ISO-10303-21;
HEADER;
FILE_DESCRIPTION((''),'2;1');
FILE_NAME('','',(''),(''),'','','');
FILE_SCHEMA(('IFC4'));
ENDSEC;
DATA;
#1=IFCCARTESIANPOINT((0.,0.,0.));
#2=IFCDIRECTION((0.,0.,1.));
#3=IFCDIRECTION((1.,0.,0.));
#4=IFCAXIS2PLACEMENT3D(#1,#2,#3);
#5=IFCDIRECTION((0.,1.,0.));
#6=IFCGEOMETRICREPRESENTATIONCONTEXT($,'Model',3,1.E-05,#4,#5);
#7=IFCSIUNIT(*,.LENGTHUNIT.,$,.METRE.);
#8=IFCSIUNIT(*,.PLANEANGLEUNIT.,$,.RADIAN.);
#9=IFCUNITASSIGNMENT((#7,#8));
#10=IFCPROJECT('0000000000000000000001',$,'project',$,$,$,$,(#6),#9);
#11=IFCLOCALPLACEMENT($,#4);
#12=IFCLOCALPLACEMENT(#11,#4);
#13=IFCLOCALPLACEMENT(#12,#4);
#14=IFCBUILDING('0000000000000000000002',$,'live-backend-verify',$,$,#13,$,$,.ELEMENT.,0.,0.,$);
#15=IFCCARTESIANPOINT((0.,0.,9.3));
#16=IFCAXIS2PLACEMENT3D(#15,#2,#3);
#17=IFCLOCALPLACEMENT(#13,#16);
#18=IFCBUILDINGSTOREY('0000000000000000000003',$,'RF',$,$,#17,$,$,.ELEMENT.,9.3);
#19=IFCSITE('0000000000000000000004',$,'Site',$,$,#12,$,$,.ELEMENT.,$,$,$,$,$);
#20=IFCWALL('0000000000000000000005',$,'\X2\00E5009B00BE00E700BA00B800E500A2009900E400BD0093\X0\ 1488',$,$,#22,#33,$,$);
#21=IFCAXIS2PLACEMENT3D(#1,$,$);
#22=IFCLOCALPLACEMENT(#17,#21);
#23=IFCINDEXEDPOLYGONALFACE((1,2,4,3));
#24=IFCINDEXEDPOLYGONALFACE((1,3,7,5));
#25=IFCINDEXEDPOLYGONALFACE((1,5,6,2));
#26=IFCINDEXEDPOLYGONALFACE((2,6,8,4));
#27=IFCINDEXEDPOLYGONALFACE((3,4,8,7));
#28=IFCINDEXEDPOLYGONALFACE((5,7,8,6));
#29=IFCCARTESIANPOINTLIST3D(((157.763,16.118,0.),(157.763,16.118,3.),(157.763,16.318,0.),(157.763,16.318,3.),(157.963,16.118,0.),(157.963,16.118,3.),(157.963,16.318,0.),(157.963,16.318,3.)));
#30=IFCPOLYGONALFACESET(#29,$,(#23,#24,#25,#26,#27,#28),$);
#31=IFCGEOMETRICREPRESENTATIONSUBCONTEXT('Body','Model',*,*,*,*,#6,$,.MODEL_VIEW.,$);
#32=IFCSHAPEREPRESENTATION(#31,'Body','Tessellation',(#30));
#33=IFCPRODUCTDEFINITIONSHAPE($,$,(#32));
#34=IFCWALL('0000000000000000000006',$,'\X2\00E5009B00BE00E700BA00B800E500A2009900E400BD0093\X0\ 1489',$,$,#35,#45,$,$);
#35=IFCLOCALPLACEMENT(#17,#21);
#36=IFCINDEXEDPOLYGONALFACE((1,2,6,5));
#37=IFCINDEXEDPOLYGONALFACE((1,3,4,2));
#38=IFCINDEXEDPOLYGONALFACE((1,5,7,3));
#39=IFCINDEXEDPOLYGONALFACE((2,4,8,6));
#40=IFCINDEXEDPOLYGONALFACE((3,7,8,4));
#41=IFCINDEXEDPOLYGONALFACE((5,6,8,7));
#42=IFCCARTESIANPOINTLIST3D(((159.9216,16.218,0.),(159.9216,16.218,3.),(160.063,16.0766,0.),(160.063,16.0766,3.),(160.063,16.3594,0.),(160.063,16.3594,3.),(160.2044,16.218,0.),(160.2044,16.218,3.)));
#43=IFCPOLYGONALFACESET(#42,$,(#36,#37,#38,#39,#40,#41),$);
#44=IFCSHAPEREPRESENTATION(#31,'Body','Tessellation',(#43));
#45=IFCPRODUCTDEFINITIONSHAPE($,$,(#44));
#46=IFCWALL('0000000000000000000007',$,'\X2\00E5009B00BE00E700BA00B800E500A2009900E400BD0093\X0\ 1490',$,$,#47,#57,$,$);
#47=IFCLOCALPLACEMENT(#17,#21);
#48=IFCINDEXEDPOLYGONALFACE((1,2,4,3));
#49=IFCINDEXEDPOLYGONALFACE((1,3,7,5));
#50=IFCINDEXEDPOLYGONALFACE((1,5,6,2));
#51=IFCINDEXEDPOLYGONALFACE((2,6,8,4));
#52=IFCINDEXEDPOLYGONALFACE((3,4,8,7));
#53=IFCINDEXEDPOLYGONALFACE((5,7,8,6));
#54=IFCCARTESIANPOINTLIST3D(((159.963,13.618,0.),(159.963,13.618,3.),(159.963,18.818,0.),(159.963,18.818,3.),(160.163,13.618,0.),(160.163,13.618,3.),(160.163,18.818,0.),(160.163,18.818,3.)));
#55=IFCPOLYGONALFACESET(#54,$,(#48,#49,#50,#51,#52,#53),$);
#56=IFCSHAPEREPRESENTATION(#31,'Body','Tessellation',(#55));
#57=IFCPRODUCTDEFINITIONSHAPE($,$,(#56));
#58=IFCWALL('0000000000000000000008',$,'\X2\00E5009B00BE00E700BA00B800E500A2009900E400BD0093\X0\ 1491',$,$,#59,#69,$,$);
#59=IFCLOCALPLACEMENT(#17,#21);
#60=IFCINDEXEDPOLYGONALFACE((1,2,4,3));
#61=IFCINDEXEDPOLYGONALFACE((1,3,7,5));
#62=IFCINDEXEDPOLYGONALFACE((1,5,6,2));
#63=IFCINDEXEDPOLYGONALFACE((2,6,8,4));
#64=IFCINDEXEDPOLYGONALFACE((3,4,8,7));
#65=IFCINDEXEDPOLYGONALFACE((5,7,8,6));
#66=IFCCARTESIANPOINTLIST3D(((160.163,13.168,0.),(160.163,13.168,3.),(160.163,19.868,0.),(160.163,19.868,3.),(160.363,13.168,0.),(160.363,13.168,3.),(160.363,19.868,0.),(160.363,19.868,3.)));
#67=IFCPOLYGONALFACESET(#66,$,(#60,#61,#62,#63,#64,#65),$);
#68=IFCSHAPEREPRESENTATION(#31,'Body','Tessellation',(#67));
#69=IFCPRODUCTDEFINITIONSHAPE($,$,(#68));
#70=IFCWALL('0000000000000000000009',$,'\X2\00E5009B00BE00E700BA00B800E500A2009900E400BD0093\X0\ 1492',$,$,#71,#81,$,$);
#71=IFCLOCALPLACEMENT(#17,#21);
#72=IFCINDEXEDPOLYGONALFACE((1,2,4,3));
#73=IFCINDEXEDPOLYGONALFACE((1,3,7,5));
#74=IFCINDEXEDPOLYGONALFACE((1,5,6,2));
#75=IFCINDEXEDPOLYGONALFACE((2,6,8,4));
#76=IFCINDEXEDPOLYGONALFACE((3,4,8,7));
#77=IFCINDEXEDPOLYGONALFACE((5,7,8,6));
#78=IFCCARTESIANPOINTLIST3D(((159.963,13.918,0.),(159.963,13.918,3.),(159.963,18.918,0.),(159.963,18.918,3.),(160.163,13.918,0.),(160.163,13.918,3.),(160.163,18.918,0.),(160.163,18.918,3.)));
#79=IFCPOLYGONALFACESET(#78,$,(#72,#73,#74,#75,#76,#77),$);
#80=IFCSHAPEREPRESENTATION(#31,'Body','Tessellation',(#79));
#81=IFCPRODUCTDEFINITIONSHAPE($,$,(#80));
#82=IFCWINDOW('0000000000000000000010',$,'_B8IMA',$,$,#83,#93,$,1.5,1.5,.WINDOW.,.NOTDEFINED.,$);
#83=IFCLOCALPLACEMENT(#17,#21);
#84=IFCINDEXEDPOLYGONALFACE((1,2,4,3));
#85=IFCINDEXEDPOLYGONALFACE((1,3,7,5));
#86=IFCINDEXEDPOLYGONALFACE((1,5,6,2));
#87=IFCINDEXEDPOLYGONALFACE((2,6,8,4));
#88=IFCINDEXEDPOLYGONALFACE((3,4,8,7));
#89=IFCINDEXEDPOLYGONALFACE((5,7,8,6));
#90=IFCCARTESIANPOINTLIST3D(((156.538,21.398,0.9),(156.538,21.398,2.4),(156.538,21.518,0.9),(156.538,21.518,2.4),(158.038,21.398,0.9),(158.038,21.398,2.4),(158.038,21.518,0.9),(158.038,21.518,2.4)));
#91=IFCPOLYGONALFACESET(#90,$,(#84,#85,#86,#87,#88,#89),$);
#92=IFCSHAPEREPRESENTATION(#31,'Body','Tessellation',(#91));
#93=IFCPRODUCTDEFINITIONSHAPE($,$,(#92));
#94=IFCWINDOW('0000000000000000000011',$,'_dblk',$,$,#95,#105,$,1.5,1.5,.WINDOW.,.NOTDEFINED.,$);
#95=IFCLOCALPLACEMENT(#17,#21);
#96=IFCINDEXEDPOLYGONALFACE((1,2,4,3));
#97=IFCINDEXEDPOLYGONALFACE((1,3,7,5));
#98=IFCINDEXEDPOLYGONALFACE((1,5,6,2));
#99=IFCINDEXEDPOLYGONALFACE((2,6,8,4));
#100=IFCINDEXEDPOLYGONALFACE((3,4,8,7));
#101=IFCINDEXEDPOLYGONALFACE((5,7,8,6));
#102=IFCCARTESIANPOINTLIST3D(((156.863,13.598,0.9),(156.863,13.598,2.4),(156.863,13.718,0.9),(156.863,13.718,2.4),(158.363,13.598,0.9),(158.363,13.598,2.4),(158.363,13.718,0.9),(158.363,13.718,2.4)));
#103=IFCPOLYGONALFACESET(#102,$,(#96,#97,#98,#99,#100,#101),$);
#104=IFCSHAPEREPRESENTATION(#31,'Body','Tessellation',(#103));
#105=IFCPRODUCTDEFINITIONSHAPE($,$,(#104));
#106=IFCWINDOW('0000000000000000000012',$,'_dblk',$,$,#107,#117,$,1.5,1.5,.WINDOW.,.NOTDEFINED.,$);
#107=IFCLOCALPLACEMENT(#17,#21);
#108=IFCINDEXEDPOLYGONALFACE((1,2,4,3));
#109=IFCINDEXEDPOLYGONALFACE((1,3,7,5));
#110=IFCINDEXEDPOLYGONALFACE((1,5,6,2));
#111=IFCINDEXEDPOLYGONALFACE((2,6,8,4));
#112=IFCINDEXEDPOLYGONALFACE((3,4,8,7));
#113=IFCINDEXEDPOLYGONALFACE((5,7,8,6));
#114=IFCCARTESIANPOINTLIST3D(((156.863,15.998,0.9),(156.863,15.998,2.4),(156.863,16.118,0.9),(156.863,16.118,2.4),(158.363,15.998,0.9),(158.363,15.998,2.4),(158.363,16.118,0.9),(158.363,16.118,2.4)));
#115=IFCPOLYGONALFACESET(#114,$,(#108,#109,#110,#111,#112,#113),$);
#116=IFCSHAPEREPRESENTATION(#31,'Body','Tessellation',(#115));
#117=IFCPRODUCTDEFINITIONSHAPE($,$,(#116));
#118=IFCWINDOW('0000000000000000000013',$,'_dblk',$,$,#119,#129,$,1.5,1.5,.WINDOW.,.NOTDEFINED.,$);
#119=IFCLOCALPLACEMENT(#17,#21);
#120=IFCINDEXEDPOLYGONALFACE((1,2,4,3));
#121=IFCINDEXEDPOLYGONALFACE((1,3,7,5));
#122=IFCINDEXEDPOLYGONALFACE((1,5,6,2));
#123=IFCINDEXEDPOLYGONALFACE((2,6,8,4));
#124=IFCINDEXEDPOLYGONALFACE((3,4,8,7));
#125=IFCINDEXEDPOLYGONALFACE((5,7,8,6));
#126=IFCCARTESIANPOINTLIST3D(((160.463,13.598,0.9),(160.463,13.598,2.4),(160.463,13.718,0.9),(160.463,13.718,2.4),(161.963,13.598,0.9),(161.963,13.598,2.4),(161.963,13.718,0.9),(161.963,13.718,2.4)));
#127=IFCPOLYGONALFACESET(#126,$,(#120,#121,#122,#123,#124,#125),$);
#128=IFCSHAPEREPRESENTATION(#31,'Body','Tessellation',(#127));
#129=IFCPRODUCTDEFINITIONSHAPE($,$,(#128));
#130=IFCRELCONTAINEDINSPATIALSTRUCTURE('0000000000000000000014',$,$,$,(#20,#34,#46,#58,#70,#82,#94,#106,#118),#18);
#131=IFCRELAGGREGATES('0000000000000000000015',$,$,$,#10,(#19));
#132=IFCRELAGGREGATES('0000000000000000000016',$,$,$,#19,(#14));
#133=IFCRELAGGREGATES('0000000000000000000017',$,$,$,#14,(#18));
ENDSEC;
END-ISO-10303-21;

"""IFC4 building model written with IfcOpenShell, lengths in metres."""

from ifc_helpers import new_model, si_unit, direction, frame, frame_2d, origin_with_axes, place, context, subcontext, project, spatial, rectangle, extrude, element, save


model = new_model("IFC4")

# Units and contexts
model_context = context("Model", 3, precision=1e-05, world=origin_with_axes(), true_north=direction((0.0, 1.0, 0.0)))
body_context = subcontext(model_context, "Body", "Model", "MODEL_VIEW")
ifc_project = project(units=[si_unit("LENGTHUNIT", "METRE"), si_unit("PLANEANGLEUNIT", "RADIAN")], contexts=[model_context])

# Site, building, storey
placement = place(None, origin_with_axes())
site_placement = place(placement, origin_with_axes())
site = spatial("IfcSite", under=ifc_project, at=site_placement, Name="Site", CompositionType="ELEMENT")
building_placement = place(site_placement, origin_with_axes())
building = spatial("IfcBuilding", under=site, at=building_placement, Name="live-backend-verify", CompositionType="ELEMENT", ElevationOfRefHeight=0.0, ElevationOfTerrain=0.0)
storey_placement = place(building_placement, frame((0.0, 0.0, 9.3), z_axis=(0.0, 0.0, 1.0), x_axis=(1.0, 0.0, 0.0)))
storey = spatial("IfcBuildingStorey", under=building, at=storey_placement, Name="RF", CompositionType="ELEMENT", Elevation=9.3)

# Walls
for number, where, z_axis, x_axis, name in (
    (1, (157.863, 16.218, 0.0), (0.0, 0.0, 1.0), (0.0, -1.0, 0.0), "å\u009b¾çº¸å¢\u0099ä½\u0093 1488"),
    (2, (160.063, 16.218, 0.0), (0.0, 0.0, 1.0), (-0.707107, -0.707107, 0.0), "å\u009b¾çº¸å¢\u0099ä½\u0093 1489"),
):
    element("IfcWall", number, at=place(storey_placement, frame(where, z_axis=z_axis, x_axis=x_axis)), inside=storey, Name=name, context=body_context, shape_type="SweptSolid", body=[
        extrude(rectangle(XDim=0.2, YDim=0.2, at=frame_2d((0.0, 0.0), x_axis=(1.0, 0.0, 0.0))), frame((0.0, 0.0, 0.0), z_axis=(0.0, 0.0, 1.0)), (0.0, 0.0, 1.0), 3.0),
    ])
wall_1_placement = place(storey_placement, frame((160.063, 16.218, 0.0), z_axis=(0.0, 0.0, 1.0), x_axis=(0.0, 1.0, 0.0)))
element("IfcWall", 3, at=wall_1_placement, inside=storey, Name="å\u009b¾çº¸å¢\u0099ä½\u0093 1490", context=body_context, shape_type="SweptSolid", body=[
    extrude(rectangle(XDim=5.2, YDim=0.2, at=frame_2d((0.0, 0.0), x_axis=(1.0, 0.0, 0.0))), frame((0.0, 0.0, 0.0), z_axis=(0.0, 0.0, 1.0)), (0.0, 0.0, 1.0), 3.0),
])
wall_2_placement = place(storey_placement, frame((160.263, 16.518, 0.0), z_axis=(0.0, 0.0, 1.0), x_axis=(0.0, 1.0, 0.0)))
element("IfcWall", 4, at=wall_2_placement, inside=storey, Name="å\u009b¾çº¸å¢\u0099ä½\u0093 1491", context=body_context, shape_type="SweptSolid", body=[
    extrude(rectangle(XDim=6.7, YDim=0.2, at=frame_2d((0.0, 0.0), x_axis=(1.0, 0.0, 0.0))), frame((0.0, 0.0, 0.0), z_axis=(0.0, 0.0, 1.0)), (0.0, 0.0, 1.0), 3.0),
])
wall_3_placement = place(storey_placement, frame((160.063, 16.418, 0.0), z_axis=(0.0, 0.0, 1.0), x_axis=(0.0, 1.0, 0.0)))
element("IfcWall", 5, at=wall_3_placement, inside=storey, Name="å\u009b¾çº¸å¢\u0099ä½\u0093 1492", context=body_context, shape_type="SweptSolid", body=[
    extrude(rectangle(XDim=5.0, YDim=0.2, at=frame_2d((0.0, 0.0), x_axis=(1.0, 0.0, 0.0))), frame((0.0, 0.0, 0.0), z_axis=(0.0, 0.0, 1.0)), (0.0, 0.0, 1.0), 3.0),
])

# Windows
for number, where, z_axis, x_axis, name in (
    (6, (157.288, 21.458, 0.9), (0.0, 0.0, 1.0), (1.0, 0.0, 0.0), "_B8IMA"),
    (7, (157.613, 13.658, 0.9), (0.0, 0.0, 1.0), (1.0, 0.0, 0.0), "_dblk"),
    (8, (157.613, 16.058, 0.9), (0.0, 0.0, 1.0), (1.0, 0.0, 0.0), "_dblk"),
    (9, (161.213, 13.658, 0.9), (0.0, 0.0, 1.0), (1.0, 0.0, 0.0), "_dblk"),
):
    element("IfcWindow", number, at=place(storey_placement, frame(where, z_axis=z_axis, x_axis=x_axis)), inside=storey, Name=name, OverallHeight=1.5, OverallWidth=1.5, PartitioningType="NOTDEFINED", PredefinedType="WINDOW", context=body_context, shape_type="SweptSolid", body=[
        extrude(rectangle(XDim=1.5, YDim=0.12, at=frame_2d((0.0, 0.0), x_axis=(1.0, 0.0, 0.0))), frame((0.0, 0.0, 0.0), z_axis=(0.0, 0.0, 1.0)), (0.0, 0.0, 1.0), 1.5),
    ])

save(model, "model.ifc")
